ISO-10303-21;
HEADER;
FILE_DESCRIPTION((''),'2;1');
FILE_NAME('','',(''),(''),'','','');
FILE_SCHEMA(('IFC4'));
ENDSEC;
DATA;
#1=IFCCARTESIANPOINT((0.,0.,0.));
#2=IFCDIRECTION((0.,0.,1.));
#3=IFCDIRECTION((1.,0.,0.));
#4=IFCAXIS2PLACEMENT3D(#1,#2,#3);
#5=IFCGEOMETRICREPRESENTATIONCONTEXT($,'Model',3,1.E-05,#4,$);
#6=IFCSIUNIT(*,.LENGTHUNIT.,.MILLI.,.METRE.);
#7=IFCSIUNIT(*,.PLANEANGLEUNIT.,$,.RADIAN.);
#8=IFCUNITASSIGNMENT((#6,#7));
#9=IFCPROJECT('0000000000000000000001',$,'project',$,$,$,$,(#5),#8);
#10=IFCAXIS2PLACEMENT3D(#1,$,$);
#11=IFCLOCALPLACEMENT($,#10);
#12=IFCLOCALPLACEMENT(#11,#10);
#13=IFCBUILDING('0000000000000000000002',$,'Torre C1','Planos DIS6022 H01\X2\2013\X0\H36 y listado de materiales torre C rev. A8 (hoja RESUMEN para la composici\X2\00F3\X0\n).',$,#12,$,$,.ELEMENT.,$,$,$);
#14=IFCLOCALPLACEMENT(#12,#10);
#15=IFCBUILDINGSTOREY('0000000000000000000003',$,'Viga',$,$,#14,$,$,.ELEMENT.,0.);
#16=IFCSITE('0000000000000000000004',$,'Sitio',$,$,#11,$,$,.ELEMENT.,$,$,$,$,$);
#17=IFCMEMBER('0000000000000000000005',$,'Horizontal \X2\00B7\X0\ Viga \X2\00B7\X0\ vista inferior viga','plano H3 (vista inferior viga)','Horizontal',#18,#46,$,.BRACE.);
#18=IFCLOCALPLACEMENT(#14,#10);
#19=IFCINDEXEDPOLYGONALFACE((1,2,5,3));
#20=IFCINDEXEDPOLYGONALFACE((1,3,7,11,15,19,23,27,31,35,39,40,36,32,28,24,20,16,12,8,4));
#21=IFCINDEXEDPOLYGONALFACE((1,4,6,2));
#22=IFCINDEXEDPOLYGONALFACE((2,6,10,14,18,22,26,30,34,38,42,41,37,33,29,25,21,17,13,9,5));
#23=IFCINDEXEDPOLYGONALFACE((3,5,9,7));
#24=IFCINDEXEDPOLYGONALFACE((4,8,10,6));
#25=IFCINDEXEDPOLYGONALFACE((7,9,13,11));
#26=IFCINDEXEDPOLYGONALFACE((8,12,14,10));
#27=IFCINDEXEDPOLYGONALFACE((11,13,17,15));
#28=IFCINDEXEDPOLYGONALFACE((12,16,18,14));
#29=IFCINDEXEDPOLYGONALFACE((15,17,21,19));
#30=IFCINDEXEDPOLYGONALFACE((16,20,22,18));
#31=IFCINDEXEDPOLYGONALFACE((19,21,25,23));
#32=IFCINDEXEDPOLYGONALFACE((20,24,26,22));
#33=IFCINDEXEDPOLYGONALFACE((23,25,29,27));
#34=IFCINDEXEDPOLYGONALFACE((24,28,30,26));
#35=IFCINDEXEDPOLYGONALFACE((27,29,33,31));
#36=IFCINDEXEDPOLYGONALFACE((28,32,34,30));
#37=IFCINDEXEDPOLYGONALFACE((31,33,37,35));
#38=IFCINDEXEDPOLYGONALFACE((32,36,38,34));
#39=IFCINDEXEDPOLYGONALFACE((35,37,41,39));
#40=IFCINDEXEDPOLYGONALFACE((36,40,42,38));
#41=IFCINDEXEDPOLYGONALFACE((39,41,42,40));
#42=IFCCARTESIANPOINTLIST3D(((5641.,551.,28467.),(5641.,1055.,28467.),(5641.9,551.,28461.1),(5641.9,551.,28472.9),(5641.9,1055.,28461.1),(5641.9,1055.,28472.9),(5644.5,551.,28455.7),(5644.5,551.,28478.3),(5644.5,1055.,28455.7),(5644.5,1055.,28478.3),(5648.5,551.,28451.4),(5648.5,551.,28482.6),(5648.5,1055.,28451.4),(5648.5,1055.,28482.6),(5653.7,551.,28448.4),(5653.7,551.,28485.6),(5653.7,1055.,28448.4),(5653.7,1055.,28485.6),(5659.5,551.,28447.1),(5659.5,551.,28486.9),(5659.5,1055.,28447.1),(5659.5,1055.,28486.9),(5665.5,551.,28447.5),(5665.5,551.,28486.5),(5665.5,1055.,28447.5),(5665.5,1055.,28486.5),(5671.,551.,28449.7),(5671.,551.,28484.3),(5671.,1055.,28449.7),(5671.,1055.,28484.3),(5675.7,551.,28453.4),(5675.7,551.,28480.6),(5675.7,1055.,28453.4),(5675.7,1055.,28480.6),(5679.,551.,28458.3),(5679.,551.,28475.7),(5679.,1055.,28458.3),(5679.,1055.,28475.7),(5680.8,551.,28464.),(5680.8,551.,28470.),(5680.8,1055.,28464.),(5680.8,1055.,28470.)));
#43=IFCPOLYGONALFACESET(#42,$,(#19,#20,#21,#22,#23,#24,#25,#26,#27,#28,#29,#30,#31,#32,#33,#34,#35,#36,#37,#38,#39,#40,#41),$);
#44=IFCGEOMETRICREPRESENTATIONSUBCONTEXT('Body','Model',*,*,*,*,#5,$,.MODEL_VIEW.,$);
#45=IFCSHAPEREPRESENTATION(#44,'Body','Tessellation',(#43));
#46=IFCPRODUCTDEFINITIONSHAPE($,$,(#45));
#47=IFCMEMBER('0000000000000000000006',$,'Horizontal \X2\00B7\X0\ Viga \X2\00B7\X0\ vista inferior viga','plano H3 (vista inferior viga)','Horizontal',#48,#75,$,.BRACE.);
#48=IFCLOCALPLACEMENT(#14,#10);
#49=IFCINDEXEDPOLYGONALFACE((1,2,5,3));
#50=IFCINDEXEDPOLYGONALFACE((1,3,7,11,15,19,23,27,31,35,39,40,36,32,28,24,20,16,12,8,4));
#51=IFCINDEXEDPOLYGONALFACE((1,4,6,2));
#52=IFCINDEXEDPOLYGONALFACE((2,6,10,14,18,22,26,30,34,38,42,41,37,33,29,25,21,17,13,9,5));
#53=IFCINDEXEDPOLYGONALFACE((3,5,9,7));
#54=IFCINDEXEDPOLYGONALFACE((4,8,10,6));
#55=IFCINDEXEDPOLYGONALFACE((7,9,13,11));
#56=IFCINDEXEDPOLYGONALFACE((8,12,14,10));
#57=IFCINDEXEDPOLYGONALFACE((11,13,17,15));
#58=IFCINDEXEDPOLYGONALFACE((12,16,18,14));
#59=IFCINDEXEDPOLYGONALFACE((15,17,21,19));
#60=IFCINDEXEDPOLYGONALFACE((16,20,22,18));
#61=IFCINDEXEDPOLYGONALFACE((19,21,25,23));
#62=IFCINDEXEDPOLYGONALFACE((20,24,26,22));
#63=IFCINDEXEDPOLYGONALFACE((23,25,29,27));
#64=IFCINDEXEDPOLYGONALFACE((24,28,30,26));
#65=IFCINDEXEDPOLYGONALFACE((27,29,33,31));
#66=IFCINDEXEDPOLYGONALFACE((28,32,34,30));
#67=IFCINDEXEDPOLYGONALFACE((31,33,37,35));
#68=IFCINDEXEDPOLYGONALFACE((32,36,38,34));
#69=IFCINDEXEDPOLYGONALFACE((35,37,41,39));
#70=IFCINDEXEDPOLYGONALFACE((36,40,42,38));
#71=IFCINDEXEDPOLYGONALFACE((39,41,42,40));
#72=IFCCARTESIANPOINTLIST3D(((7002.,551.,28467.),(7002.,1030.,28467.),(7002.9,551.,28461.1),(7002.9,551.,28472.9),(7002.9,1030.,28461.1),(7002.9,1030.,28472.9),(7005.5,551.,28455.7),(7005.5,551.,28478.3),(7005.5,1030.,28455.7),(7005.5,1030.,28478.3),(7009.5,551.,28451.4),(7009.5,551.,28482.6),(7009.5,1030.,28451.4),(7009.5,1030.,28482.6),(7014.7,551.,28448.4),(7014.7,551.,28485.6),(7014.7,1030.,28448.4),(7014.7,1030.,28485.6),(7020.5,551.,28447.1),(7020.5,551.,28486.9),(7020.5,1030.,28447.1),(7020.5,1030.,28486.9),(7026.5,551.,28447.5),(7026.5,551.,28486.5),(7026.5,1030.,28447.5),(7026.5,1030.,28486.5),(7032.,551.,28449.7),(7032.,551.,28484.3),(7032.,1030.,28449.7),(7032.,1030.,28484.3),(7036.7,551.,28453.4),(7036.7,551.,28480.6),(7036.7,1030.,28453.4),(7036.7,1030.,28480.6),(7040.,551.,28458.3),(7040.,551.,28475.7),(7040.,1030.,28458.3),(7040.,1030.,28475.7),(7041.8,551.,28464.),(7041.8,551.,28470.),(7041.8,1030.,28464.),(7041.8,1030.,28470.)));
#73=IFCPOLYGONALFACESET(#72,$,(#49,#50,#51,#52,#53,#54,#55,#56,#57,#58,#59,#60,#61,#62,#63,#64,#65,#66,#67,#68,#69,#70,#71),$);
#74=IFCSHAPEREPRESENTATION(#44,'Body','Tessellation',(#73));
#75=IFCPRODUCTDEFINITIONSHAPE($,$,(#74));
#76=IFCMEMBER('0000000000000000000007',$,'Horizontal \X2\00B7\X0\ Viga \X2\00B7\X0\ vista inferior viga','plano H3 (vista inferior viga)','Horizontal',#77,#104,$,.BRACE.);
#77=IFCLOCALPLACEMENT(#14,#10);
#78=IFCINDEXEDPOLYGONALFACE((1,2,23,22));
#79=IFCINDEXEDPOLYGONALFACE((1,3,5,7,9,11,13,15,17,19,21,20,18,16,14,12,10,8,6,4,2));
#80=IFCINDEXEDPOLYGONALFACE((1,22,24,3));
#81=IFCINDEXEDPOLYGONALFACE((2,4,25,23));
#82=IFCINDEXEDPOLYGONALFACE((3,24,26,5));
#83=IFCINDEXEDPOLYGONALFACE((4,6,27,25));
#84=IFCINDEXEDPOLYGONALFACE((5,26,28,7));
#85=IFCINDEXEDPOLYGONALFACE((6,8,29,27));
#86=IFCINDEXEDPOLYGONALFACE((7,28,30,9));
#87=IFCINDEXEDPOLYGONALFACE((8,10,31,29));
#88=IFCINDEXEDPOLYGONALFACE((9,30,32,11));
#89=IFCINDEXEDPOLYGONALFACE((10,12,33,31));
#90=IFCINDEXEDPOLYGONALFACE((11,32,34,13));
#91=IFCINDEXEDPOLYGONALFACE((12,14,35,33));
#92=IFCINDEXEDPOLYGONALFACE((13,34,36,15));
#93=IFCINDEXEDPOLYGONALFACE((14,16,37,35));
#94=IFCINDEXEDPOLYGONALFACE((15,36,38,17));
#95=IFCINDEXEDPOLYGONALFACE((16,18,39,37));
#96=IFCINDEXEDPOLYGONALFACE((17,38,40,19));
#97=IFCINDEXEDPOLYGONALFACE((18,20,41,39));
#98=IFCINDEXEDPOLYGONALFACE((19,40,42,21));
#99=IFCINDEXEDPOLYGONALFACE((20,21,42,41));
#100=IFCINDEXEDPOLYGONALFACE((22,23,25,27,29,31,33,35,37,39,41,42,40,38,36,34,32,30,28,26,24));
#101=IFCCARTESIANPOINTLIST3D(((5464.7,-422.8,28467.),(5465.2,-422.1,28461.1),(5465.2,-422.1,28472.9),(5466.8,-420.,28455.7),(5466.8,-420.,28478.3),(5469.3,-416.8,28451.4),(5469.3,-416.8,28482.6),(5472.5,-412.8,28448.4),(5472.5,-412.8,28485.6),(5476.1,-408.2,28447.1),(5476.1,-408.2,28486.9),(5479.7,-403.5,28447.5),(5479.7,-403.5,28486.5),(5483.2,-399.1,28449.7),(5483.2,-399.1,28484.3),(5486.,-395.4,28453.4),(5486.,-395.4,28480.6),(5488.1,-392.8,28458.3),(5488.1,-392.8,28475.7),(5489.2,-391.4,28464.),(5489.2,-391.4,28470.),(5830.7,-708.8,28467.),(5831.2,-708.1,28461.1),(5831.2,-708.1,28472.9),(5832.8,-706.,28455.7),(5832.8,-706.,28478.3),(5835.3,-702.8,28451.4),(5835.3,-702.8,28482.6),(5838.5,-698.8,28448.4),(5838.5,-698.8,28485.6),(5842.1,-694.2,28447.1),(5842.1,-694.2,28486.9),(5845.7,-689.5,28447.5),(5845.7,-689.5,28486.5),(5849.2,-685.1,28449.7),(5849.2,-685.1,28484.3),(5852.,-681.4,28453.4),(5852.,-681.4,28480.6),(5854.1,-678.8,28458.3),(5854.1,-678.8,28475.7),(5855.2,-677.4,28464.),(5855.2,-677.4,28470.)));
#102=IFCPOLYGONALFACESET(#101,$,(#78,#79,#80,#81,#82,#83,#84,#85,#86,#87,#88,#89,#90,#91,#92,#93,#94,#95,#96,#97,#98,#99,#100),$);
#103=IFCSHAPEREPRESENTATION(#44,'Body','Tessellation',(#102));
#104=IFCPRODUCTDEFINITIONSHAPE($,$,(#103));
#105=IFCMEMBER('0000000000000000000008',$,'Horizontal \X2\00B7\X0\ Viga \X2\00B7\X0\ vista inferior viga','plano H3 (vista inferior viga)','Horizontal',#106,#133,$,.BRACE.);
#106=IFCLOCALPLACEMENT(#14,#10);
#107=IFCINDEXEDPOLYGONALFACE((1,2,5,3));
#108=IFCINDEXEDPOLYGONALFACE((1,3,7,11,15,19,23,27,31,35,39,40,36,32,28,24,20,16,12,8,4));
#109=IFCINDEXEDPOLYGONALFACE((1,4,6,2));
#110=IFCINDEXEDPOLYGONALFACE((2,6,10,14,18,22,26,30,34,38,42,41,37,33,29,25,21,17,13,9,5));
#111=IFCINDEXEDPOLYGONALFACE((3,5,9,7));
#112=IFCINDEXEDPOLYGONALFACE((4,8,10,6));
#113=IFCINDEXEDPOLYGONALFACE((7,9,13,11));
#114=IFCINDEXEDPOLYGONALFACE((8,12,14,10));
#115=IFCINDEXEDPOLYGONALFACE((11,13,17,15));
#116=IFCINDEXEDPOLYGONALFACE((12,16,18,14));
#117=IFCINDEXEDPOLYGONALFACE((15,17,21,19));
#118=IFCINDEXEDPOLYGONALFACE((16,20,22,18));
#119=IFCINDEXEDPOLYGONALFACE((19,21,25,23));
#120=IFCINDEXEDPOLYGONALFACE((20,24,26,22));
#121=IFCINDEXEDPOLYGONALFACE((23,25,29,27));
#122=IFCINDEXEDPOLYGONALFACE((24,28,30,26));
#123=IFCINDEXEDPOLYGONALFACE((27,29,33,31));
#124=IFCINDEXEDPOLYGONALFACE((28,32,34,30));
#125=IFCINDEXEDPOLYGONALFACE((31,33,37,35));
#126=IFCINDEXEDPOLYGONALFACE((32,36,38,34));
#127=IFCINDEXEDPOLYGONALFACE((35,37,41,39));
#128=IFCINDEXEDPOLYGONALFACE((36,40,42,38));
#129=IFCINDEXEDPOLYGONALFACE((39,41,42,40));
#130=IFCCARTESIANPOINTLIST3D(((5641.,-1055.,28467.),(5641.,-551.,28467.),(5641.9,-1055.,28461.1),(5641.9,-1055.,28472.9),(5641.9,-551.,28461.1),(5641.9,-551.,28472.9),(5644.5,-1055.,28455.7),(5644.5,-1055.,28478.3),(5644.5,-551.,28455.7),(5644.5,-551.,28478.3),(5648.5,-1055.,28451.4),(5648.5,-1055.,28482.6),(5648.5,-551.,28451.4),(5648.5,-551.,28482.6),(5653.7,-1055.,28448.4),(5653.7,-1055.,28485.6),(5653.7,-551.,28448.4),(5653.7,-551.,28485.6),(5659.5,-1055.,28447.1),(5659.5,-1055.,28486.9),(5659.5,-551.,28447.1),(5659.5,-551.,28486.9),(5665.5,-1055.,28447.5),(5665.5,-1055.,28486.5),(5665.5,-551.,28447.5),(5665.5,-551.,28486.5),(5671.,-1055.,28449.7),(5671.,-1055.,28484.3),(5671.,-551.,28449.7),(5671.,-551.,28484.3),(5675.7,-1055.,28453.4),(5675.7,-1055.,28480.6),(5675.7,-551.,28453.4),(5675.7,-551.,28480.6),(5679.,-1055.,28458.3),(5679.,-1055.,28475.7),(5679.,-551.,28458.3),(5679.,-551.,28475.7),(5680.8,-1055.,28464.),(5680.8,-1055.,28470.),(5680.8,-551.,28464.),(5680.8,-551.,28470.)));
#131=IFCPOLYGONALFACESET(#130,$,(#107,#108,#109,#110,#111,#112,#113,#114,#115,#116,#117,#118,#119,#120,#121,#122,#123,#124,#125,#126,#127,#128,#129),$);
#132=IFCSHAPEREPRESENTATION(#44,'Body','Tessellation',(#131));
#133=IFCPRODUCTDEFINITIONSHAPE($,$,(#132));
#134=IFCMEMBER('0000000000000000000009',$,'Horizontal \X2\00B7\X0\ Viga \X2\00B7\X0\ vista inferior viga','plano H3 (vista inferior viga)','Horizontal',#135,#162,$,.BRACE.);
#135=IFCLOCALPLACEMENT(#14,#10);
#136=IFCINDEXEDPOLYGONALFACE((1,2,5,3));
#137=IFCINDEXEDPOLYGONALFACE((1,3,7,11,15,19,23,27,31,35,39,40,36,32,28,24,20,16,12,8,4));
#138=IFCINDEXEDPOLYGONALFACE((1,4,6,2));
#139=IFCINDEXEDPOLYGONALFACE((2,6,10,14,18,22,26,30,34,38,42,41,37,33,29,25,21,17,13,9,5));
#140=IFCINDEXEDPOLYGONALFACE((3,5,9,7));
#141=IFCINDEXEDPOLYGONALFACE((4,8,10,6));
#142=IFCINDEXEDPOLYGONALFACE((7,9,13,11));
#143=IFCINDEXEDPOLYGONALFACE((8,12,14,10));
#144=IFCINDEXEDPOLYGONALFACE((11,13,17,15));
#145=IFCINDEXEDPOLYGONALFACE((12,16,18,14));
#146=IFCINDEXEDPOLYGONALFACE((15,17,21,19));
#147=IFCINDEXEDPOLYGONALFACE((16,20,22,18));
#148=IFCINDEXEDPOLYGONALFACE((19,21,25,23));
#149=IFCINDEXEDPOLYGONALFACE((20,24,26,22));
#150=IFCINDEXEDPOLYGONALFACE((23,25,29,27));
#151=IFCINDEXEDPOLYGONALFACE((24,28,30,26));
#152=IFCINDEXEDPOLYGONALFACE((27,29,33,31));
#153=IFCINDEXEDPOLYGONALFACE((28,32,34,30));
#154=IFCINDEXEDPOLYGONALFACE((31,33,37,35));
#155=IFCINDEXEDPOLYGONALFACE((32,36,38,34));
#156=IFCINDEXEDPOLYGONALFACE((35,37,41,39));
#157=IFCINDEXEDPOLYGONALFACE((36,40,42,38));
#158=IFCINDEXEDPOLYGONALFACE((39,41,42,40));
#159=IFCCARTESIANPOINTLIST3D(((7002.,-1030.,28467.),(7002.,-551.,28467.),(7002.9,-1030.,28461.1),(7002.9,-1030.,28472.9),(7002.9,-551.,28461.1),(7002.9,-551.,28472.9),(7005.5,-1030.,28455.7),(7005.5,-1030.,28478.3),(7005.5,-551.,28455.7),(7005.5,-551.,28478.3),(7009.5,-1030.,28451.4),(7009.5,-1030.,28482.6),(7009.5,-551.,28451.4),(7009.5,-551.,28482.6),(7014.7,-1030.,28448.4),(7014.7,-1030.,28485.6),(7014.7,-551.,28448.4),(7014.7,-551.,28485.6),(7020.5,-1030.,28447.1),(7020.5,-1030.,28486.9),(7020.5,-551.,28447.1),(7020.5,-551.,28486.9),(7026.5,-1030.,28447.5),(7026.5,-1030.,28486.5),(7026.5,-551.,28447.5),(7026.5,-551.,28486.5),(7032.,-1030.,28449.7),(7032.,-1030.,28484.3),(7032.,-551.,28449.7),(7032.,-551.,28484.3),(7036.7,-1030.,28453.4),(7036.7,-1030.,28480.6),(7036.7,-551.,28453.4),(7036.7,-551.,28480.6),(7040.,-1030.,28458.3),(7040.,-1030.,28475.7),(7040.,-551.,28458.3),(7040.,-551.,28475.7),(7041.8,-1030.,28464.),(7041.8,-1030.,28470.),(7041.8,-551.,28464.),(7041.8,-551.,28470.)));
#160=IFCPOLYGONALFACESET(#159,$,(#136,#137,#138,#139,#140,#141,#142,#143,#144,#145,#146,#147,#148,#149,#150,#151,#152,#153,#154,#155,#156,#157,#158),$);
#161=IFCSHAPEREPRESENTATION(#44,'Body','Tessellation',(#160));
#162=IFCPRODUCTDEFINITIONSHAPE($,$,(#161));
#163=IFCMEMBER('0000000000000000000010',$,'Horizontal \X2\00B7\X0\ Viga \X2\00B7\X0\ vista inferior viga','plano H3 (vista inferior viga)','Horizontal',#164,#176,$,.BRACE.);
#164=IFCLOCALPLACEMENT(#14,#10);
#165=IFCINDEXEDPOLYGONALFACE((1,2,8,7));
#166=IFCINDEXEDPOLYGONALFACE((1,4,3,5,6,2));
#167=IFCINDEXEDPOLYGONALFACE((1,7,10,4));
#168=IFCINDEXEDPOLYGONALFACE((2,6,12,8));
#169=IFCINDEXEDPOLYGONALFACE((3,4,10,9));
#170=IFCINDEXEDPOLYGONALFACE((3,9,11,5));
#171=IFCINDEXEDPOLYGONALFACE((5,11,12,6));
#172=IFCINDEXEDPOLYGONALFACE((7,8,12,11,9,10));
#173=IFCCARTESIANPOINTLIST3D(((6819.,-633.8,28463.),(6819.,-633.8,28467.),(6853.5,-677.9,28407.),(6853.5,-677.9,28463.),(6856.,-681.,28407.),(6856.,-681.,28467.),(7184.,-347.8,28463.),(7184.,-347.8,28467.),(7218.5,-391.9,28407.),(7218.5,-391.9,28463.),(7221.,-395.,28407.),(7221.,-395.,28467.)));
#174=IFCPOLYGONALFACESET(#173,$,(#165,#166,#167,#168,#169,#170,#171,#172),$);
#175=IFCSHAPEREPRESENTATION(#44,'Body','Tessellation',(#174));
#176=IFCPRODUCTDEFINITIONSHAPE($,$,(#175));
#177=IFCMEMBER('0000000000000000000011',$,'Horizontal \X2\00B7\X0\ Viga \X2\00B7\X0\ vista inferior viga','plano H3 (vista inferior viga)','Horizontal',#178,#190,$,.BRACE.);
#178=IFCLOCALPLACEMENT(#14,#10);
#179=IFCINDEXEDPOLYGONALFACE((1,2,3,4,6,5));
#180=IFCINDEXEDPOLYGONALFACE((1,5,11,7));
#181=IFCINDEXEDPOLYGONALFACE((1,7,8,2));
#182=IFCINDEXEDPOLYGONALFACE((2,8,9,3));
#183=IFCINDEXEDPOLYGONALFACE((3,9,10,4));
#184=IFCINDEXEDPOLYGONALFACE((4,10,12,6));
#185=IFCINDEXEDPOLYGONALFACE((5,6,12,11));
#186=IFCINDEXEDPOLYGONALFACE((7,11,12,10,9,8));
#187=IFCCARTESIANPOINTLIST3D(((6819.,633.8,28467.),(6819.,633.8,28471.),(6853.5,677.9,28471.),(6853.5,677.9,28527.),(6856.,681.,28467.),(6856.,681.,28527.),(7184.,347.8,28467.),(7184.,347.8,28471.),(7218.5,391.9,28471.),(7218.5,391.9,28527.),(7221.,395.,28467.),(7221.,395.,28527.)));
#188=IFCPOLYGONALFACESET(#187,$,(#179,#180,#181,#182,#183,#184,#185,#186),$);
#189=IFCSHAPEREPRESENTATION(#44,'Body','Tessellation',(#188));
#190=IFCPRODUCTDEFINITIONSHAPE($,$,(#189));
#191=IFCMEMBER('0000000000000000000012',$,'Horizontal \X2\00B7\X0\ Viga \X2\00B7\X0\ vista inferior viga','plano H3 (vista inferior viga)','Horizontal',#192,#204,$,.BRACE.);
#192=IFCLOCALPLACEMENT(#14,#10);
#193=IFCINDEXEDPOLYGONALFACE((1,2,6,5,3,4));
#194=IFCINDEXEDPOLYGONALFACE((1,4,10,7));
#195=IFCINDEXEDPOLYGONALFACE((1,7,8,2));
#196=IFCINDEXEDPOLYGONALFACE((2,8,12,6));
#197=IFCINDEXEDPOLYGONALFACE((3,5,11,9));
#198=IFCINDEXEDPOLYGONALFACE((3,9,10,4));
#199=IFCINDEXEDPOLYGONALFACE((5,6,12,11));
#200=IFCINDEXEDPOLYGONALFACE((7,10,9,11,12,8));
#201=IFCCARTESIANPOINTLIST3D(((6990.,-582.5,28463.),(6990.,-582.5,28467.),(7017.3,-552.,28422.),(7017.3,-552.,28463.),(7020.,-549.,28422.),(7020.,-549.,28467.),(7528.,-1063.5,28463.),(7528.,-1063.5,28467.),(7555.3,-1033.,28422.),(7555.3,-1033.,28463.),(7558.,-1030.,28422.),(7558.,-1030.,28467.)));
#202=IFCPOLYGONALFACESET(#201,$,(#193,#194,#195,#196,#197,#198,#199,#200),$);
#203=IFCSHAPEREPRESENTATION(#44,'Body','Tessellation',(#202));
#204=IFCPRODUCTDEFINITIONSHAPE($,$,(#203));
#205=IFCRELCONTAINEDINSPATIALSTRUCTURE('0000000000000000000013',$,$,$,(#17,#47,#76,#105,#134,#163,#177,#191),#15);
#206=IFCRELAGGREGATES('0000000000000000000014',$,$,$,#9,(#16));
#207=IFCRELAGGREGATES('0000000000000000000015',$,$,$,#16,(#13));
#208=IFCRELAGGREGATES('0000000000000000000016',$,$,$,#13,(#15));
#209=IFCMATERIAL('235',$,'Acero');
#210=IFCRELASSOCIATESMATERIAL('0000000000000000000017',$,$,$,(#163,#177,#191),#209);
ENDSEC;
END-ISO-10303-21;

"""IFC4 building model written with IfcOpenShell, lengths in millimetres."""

from ifc_helpers import new_model, si_unit, frame, frame_2d, origin, origin_with_axes, place, context, subcontext, project, spatial, circle, l_section, extrude, material, element, save


model = new_model("IFC4")

# Units and contexts
model_context = context("Model", 3, precision=1e-05, world=origin_with_axes())
body_context = subcontext(model_context, "Body", "Model", "MODEL_VIEW")
ifc_project = project(units=[si_unit("LENGTHUNIT", "METRE", prefix="MILLI"), si_unit("PLANEANGLEUNIT", "RADIAN")], contexts=[model_context])

# Site, building, storey
site_placement = place(None, origin())
site = spatial("IfcSite", under=ifc_project, at=site_placement, Name="Sitio", CompositionType="ELEMENT")
building_placement = place(site_placement, origin())
building = spatial("IfcBuilding", under=site, at=building_placement, Name="Torre C1", Description="Planos DIS6022 H01–H36 y listado de materiales torre C rev. A8 (hoja RESUMEN para la composición).", CompositionType="ELEMENT")
storey_placement = place(building_placement, origin())
storey = spatial("IfcBuildingStorey", under=building, at=storey_placement, Name="Viga", CompositionType="ELEMENT", Elevation=0.0)

# Members
ifc_material_1 = material(Name="235", Category="Acero")
member_1_placement = place(storey_placement, frame((5661.0, 551.0, 28467.0), z_axis=(0.0, 1.0, 0.0), x_axis=(-1.0, 0.0, 0.0)))
element("IfcMember", 1, at=member_1_placement, inside=storey, Name="Horizontal · Viga · vista inferior viga", Description="plano H3 (vista inferior viga)", ObjectType="Horizontal", PredefinedType="BRACE", context=body_context, shape_type="SweptSolid", body=[
    extrude(circle(Radius=20.0), None, (0.0, 0.0, 1.0), 504.0),
])
member_2_placement = place(storey_placement, frame((7022.0, 551.0, 28467.0), z_axis=(0.0, 1.0, 0.0), x_axis=(-1.0, 0.0, 0.0)))
element("IfcMember", 2, at=member_2_placement, inside=storey, Name="Horizontal · Viga · vista inferior viga", Description="plano H3 (vista inferior viga)", ObjectType="Horizontal", PredefinedType="BRACE", context=body_context, shape_type="SweptSolid", body=[
    extrude(circle(Radius=20.0), None, (0.0, 0.0, 1.0), 479.0),
])
member_3_placement = place(storey_placement, frame((5477.0, -407.0, 28467.0), z_axis=(0.787959, -0.615728, 0.0), x_axis=(-0.615728, -0.787959, 0.0)))
element("IfcMember", 3, at=member_3_placement, inside=storey, Name="Horizontal · Viga · vista inferior viga", Description="plano H3 (vista inferior viga)", ObjectType="Horizontal", PredefinedType="BRACE", context=body_context, shape_type="SweptSolid", body=[
    extrude(circle(Radius=20.0), None, (0.0, 0.0, 1.0), 464.5),
])
member_4_placement = place(storey_placement, frame((5661.0, -551.0, 28467.0), z_axis=(0.0, -1.0, 0.0), x_axis=(-1.0, 0.0, 0.0)))
element("IfcMember", 4, at=member_4_placement, inside=storey, Name="Horizontal · Viga · vista inferior viga", Description="plano H3 (vista inferior viga)", ObjectType="Horizontal", PredefinedType="BRACE", context=body_context, shape_type="SweptSolid", body=[
    extrude(circle(Radius=20.0), None, (0.0, 0.0, 1.0), 504.0),
])
member_5_placement = place(storey_placement, frame((7022.0, -551.0, 28467.0), z_axis=(0.0, -1.0, 0.0), x_axis=(-1.0, 0.0, 0.0)))
element("IfcMember", 5, at=member_5_placement, inside=storey, Name="Horizontal · Viga · vista inferior viga", Description="plano H3 (vista inferior viga)", ObjectType="Horizontal", PredefinedType="BRACE", context=body_context, shape_type="SweptSolid", body=[
    extrude(circle(Radius=20.0), None, (0.0, 0.0, 1.0), 479.0),
])
for number, where, z_axis, x_axis, name in (
    (6, (7221.0, -395.0, 28467.0), (-0.787141, -0.616773, 0.0), (-0.616773, 0.787141, 0.0), "Horizontal · Viga · vista inferior viga"),
    (7, (7221.0, 395.0, 28467.0), (-0.787141, 0.616773, 0.0), (-0.616773, -0.787141, 0.0), "Horizontal · Viga · vista inferior viga"),
):
    element("IfcMember", number, at=place(storey_placement, frame(where, z_axis=z_axis, x_axis=x_axis)), inside=storey, material=ifc_material_1, Name=name, Description="plano H3 (vista inferior viga)", ObjectType="Horizontal", PredefinedType="BRACE", context=body_context, shape_type="SweptSolid", body=[
        extrude(l_section(Depth=60.0, Width=60.0, Thickness=4.0, at=frame_2d((30.0, 30.0))), None, (0.0, 0.0, 1.0), 463.7),
    ])
member_6_placement = place(storey_placement, frame((7020.0, -549.0, 28467.0), z_axis=(0.745495, -0.666511, 0.0), x_axis=(-0.666511, -0.745495, 0.0)))
element("IfcMember", 8, at=member_6_placement, inside=storey, material=ifc_material_1, Name="Horizontal · Viga · vista inferior viga", Description="plano H3 (vista inferior viga)", ObjectType="Horizontal", PredefinedType="BRACE", context=body_context, shape_type="SweptSolid", body=[
    extrude(l_section(Depth=45.0, Width=45.0, Thickness=4.0, at=frame_2d((22.5, 22.5))), None, (0.0, 0.0, 1.0), 721.7),
])

save(model, "model.ifc")
